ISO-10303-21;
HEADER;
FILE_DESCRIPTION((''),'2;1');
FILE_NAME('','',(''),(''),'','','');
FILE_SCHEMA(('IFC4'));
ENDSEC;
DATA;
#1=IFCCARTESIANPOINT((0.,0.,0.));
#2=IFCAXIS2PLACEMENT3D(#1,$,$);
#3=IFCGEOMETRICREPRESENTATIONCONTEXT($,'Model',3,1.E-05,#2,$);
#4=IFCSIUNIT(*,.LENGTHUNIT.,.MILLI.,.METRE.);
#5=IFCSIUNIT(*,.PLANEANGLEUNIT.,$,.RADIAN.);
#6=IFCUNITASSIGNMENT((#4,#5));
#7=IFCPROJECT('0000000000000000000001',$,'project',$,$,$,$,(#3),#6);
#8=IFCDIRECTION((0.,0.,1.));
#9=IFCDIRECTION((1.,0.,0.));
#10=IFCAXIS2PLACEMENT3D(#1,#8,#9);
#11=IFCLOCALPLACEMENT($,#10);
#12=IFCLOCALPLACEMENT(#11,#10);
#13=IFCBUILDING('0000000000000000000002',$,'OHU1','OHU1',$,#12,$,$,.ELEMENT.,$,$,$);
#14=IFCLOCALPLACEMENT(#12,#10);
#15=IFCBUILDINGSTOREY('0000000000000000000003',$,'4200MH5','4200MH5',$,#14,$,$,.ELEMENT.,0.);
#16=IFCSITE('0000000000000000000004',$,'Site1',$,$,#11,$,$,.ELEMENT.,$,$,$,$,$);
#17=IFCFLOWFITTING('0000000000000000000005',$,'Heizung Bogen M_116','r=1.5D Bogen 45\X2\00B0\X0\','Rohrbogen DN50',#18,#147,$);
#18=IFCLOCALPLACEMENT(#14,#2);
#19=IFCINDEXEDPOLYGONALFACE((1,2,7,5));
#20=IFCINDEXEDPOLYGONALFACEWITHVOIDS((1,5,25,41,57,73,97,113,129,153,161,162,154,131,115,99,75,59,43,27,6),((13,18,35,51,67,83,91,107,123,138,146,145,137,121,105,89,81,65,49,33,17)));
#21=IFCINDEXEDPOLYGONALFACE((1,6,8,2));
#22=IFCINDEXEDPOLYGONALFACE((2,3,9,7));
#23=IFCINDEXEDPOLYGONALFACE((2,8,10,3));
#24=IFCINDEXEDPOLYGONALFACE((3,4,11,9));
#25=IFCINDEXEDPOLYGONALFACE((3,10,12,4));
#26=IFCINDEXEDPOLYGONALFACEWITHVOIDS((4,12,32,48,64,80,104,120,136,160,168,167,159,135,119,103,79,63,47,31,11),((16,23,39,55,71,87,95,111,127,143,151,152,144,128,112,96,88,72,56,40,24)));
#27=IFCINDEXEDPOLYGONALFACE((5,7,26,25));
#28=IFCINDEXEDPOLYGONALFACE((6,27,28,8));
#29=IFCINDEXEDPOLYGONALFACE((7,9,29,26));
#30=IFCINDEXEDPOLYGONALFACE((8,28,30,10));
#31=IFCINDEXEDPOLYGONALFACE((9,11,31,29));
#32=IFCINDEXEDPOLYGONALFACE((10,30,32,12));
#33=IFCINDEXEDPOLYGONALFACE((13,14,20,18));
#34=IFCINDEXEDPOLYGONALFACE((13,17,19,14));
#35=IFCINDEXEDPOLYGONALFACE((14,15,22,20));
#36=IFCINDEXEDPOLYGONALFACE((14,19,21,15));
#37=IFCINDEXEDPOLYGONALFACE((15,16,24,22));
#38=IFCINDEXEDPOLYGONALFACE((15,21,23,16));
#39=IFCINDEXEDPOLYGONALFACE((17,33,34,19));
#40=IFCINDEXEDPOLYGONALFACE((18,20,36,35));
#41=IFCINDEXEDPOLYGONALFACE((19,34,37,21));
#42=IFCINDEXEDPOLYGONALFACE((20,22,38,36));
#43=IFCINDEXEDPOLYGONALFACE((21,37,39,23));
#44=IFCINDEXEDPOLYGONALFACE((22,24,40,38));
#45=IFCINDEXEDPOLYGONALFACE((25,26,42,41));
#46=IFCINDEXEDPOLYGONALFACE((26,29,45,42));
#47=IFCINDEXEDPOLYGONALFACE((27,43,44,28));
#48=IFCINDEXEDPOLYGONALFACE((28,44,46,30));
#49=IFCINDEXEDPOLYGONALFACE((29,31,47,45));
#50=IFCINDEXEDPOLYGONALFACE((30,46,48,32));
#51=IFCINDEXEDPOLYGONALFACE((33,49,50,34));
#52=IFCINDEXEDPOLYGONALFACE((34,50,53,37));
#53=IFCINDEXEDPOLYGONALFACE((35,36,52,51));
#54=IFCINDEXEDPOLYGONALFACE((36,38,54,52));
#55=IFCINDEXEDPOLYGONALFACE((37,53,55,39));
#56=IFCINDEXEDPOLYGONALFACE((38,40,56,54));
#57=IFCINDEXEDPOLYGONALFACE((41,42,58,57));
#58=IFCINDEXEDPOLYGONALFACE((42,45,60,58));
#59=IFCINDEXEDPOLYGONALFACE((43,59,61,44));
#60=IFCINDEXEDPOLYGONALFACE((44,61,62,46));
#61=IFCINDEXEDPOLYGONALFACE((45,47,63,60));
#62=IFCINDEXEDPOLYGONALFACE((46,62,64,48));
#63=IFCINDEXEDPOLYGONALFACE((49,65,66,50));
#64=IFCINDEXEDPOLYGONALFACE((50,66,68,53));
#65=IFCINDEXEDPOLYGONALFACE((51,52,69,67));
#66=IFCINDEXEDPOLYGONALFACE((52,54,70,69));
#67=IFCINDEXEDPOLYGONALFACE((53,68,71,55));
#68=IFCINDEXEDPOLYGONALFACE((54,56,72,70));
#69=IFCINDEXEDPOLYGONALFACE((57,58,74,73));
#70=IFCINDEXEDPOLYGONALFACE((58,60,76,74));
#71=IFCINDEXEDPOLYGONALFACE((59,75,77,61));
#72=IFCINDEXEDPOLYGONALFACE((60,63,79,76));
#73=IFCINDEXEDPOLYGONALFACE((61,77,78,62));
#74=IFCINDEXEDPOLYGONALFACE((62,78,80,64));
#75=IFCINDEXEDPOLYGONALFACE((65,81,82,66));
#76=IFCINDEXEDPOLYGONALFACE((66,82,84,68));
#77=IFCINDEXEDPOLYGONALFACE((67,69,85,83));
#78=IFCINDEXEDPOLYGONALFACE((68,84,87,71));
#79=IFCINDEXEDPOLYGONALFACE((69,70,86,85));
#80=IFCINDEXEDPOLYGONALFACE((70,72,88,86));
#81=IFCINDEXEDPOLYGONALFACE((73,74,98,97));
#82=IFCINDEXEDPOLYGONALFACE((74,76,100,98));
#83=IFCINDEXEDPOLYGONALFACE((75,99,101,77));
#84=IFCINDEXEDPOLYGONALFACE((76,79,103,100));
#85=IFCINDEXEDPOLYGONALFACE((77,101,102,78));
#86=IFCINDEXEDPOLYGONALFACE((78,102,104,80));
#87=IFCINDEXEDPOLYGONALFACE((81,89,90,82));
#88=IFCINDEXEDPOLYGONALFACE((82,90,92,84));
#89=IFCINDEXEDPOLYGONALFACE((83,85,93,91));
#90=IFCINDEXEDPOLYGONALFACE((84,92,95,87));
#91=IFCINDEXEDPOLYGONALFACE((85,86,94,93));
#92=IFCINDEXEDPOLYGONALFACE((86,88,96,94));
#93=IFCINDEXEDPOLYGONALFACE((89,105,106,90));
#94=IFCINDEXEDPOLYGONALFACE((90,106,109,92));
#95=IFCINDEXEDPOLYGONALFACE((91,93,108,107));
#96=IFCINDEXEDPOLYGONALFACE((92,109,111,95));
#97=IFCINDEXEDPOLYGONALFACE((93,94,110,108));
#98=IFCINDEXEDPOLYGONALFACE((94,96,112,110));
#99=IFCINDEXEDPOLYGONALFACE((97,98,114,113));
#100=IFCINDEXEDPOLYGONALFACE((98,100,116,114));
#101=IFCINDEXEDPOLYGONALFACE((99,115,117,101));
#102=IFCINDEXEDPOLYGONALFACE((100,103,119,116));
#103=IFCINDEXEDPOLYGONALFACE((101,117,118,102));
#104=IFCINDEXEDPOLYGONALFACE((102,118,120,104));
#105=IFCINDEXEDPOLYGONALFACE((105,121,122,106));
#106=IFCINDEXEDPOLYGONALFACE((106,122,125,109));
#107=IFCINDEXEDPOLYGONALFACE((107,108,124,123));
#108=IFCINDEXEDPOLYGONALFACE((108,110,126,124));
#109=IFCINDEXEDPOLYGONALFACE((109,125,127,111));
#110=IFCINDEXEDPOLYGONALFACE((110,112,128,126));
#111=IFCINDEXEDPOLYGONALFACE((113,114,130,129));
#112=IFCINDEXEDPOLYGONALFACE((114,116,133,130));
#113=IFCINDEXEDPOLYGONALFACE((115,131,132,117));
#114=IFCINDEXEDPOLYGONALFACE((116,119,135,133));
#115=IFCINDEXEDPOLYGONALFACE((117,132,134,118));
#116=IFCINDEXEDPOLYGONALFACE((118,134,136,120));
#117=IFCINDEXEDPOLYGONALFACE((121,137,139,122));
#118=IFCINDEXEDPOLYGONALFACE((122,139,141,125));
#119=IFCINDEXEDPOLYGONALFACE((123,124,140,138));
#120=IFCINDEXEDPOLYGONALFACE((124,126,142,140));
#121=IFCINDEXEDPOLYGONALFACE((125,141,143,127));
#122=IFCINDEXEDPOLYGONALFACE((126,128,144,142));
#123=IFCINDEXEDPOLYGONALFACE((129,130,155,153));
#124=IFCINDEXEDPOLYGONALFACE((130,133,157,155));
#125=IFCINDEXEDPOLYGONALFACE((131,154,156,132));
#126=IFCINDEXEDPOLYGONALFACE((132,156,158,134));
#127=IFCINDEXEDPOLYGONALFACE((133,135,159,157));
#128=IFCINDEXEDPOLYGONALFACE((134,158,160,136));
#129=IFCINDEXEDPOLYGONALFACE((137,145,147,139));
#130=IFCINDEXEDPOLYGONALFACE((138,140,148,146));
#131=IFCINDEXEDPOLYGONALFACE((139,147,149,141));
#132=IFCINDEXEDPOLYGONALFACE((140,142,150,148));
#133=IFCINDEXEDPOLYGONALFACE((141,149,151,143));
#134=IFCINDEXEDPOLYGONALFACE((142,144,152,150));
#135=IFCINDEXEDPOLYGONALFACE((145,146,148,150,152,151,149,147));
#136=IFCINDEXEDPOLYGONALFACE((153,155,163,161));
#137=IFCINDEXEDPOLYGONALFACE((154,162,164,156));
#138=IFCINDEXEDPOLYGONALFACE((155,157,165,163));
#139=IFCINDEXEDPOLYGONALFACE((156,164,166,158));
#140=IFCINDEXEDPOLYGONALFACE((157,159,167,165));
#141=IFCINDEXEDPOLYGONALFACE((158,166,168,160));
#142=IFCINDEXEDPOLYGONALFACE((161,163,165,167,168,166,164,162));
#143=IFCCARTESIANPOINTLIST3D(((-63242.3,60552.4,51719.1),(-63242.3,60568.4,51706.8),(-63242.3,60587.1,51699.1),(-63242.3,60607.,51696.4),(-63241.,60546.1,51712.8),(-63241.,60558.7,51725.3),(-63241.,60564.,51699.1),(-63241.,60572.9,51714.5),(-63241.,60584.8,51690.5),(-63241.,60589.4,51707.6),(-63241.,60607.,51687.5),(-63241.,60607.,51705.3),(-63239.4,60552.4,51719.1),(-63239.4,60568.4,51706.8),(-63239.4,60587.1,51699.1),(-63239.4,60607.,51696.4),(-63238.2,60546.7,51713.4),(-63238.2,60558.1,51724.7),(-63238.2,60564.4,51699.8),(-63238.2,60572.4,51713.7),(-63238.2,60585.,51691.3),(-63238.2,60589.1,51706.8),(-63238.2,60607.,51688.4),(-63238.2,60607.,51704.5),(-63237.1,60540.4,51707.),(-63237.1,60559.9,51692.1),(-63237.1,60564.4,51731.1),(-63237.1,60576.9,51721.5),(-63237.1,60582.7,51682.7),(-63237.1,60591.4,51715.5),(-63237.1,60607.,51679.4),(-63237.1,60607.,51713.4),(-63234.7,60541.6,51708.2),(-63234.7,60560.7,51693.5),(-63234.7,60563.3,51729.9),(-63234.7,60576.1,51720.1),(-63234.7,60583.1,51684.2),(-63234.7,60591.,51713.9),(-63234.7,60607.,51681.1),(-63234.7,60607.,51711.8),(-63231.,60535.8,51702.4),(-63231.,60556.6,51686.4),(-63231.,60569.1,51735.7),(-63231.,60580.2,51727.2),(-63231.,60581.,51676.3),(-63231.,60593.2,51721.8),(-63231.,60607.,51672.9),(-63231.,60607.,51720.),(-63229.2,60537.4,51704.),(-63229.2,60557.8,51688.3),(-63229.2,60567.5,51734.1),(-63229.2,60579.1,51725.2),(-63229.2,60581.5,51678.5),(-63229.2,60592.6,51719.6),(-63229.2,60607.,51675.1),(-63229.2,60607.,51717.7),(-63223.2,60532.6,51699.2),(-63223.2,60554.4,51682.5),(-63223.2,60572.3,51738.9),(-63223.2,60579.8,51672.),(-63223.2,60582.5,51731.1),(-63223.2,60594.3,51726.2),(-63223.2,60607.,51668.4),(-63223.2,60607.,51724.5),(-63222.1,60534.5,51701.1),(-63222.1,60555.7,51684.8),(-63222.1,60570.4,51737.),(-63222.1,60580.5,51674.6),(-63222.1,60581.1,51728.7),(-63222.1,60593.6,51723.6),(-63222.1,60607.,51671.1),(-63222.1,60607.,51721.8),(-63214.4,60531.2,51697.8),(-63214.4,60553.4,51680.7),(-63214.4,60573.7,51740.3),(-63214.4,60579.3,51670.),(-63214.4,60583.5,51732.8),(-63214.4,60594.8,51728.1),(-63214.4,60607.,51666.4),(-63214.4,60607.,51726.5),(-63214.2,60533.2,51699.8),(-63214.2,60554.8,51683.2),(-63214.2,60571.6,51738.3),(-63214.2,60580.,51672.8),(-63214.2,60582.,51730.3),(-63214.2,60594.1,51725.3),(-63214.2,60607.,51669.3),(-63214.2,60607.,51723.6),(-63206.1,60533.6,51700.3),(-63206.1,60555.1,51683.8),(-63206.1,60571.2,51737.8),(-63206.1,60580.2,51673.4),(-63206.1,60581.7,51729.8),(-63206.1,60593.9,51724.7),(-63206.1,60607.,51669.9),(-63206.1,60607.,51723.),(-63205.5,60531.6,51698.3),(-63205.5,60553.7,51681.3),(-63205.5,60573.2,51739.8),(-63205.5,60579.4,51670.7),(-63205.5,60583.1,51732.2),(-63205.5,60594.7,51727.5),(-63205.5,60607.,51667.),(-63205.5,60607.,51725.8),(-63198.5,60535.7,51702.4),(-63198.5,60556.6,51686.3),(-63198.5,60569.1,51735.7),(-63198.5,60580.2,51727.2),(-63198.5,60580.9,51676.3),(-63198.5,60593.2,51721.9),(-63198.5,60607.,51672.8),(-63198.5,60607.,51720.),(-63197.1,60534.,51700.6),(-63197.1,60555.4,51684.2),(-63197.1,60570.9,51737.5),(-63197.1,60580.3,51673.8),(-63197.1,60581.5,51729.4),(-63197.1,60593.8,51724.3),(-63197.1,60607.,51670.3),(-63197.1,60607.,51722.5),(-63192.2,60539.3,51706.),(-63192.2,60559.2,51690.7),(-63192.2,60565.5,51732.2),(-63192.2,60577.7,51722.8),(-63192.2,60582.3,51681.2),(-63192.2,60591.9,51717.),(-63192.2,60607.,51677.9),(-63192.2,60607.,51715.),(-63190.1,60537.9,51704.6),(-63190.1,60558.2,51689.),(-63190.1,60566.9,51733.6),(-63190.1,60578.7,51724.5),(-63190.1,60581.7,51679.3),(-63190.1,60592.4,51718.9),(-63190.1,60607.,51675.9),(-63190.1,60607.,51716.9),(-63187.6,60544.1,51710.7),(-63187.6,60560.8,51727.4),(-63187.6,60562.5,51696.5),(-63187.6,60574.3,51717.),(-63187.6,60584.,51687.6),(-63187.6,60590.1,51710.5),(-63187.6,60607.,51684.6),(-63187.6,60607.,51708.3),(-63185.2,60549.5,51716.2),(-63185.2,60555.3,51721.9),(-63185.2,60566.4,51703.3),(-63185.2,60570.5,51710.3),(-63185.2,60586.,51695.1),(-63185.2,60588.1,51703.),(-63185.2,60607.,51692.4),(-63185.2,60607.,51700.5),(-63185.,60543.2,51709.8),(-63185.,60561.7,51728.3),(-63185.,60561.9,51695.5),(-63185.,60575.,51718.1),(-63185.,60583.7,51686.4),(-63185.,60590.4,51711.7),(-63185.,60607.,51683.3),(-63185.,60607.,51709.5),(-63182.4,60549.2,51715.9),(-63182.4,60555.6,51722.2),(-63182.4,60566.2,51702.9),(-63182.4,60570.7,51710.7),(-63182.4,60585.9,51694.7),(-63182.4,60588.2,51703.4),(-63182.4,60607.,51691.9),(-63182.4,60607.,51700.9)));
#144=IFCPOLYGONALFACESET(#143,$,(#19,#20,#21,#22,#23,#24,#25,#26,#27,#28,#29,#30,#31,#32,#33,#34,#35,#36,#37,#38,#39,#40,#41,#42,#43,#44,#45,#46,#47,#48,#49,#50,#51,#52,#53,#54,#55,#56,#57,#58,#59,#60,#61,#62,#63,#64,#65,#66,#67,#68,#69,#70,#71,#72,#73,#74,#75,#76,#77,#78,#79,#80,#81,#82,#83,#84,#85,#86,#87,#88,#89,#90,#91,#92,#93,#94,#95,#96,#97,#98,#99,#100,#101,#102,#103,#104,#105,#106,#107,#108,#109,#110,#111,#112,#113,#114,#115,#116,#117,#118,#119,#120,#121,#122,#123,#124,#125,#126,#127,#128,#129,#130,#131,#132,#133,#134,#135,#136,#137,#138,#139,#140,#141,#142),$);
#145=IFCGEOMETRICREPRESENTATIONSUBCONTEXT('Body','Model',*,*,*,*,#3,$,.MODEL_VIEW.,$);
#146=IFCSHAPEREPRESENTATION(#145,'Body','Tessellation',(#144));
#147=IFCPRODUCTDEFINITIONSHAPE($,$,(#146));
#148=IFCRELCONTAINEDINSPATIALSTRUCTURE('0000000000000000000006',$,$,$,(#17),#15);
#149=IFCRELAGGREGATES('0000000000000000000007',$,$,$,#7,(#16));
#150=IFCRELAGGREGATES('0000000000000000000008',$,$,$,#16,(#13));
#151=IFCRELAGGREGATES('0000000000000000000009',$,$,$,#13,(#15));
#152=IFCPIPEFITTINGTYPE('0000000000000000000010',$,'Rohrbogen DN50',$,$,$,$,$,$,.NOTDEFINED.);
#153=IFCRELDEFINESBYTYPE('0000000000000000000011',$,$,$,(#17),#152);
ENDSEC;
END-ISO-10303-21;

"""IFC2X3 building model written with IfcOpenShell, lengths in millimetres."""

from ifc_helpers import new_model, entity, si_unit, frame, origin, origin_with_axes, place, context, subcontext, project, spatial, type_object, element, save


model = new_model("IFC2X3")

# Units and contexts
model_context = context("Model", 3, precision=1e-05, world=origin())
body_context = subcontext(model_context, "Body", "Model", "MODEL_VIEW")
ifc_project = project(units=[si_unit("LENGTHUNIT", "METRE", prefix="MILLI"), si_unit("PLANEANGLEUNIT", "RADIAN")], contexts=[model_context])

# Site, building, storey
site_placement = place(None, origin_with_axes())
site = spatial("IfcSite", under=ifc_project, at=site_placement, Name="Site1", CompositionType="ELEMENT")
building_placement = place(site_placement, origin_with_axes())
building = spatial("IfcBuilding", under=site, at=building_placement, Name="OHU1", Description="OHU1", CompositionType="ELEMENT")
storey_placement = place(building_placement, origin_with_axes())
storey = spatial("IfcBuildingStorey", under=building, at=storey_placement, Name="4200MH5", Description="4200MH5", CompositionType="ELEMENT", Elevation=0.0)

# Flow fitting
pipe_fitting_type_1 = type_object("IfcPipeFittingType", Name="Rohrbogen DN50", PredefinedType="NOTDEFINED")
flow_fitting_1_placement = place(storey_placement, frame((-63212.2, 60589.8, 51681.6), z_axis=(0.0, 0.0, 1.0), x_axis=(1.0, 0.0, 0.0)))
element("IfcFlowFitting", 1, at=flow_fitting_1_placement, inside=storey, type_object=pipe_fitting_type_1, Name="Heizung Bogen M_116", Description="r=1.5D Bogen 45°", ObjectType="Rohrbogen DN50", context=body_context, shape_type="SweptSolid", body=[
    entity("IfcRevolvedAreaSolid", entity("IfcCircleHollowProfileDef", "AREA", None, entity("IfcAxis2Placement2D", entity("IfcCartesianPoint", [0.0, 0.0]), entity("IfcDirection", [1.0, 0.0])), 30.1, 2.9), entity("IfcAxis2Placement3D", entity("IfcCartesianPoint", [0.0, -37.4, 37.4]), entity("IfcDirection", [0.000002, 0.707107, -0.707107]), entity("IfcDirection", [-1.0, 0.000003, 0.0])), entity("IfcAxis1Placement", entity("IfcCartesianPoint", [0.0, 77.3, 0.0]), entity("IfcDirection", [-1.0, 0.0, 0.0])), 0.785398),
])

save(model, "model.ifc")
